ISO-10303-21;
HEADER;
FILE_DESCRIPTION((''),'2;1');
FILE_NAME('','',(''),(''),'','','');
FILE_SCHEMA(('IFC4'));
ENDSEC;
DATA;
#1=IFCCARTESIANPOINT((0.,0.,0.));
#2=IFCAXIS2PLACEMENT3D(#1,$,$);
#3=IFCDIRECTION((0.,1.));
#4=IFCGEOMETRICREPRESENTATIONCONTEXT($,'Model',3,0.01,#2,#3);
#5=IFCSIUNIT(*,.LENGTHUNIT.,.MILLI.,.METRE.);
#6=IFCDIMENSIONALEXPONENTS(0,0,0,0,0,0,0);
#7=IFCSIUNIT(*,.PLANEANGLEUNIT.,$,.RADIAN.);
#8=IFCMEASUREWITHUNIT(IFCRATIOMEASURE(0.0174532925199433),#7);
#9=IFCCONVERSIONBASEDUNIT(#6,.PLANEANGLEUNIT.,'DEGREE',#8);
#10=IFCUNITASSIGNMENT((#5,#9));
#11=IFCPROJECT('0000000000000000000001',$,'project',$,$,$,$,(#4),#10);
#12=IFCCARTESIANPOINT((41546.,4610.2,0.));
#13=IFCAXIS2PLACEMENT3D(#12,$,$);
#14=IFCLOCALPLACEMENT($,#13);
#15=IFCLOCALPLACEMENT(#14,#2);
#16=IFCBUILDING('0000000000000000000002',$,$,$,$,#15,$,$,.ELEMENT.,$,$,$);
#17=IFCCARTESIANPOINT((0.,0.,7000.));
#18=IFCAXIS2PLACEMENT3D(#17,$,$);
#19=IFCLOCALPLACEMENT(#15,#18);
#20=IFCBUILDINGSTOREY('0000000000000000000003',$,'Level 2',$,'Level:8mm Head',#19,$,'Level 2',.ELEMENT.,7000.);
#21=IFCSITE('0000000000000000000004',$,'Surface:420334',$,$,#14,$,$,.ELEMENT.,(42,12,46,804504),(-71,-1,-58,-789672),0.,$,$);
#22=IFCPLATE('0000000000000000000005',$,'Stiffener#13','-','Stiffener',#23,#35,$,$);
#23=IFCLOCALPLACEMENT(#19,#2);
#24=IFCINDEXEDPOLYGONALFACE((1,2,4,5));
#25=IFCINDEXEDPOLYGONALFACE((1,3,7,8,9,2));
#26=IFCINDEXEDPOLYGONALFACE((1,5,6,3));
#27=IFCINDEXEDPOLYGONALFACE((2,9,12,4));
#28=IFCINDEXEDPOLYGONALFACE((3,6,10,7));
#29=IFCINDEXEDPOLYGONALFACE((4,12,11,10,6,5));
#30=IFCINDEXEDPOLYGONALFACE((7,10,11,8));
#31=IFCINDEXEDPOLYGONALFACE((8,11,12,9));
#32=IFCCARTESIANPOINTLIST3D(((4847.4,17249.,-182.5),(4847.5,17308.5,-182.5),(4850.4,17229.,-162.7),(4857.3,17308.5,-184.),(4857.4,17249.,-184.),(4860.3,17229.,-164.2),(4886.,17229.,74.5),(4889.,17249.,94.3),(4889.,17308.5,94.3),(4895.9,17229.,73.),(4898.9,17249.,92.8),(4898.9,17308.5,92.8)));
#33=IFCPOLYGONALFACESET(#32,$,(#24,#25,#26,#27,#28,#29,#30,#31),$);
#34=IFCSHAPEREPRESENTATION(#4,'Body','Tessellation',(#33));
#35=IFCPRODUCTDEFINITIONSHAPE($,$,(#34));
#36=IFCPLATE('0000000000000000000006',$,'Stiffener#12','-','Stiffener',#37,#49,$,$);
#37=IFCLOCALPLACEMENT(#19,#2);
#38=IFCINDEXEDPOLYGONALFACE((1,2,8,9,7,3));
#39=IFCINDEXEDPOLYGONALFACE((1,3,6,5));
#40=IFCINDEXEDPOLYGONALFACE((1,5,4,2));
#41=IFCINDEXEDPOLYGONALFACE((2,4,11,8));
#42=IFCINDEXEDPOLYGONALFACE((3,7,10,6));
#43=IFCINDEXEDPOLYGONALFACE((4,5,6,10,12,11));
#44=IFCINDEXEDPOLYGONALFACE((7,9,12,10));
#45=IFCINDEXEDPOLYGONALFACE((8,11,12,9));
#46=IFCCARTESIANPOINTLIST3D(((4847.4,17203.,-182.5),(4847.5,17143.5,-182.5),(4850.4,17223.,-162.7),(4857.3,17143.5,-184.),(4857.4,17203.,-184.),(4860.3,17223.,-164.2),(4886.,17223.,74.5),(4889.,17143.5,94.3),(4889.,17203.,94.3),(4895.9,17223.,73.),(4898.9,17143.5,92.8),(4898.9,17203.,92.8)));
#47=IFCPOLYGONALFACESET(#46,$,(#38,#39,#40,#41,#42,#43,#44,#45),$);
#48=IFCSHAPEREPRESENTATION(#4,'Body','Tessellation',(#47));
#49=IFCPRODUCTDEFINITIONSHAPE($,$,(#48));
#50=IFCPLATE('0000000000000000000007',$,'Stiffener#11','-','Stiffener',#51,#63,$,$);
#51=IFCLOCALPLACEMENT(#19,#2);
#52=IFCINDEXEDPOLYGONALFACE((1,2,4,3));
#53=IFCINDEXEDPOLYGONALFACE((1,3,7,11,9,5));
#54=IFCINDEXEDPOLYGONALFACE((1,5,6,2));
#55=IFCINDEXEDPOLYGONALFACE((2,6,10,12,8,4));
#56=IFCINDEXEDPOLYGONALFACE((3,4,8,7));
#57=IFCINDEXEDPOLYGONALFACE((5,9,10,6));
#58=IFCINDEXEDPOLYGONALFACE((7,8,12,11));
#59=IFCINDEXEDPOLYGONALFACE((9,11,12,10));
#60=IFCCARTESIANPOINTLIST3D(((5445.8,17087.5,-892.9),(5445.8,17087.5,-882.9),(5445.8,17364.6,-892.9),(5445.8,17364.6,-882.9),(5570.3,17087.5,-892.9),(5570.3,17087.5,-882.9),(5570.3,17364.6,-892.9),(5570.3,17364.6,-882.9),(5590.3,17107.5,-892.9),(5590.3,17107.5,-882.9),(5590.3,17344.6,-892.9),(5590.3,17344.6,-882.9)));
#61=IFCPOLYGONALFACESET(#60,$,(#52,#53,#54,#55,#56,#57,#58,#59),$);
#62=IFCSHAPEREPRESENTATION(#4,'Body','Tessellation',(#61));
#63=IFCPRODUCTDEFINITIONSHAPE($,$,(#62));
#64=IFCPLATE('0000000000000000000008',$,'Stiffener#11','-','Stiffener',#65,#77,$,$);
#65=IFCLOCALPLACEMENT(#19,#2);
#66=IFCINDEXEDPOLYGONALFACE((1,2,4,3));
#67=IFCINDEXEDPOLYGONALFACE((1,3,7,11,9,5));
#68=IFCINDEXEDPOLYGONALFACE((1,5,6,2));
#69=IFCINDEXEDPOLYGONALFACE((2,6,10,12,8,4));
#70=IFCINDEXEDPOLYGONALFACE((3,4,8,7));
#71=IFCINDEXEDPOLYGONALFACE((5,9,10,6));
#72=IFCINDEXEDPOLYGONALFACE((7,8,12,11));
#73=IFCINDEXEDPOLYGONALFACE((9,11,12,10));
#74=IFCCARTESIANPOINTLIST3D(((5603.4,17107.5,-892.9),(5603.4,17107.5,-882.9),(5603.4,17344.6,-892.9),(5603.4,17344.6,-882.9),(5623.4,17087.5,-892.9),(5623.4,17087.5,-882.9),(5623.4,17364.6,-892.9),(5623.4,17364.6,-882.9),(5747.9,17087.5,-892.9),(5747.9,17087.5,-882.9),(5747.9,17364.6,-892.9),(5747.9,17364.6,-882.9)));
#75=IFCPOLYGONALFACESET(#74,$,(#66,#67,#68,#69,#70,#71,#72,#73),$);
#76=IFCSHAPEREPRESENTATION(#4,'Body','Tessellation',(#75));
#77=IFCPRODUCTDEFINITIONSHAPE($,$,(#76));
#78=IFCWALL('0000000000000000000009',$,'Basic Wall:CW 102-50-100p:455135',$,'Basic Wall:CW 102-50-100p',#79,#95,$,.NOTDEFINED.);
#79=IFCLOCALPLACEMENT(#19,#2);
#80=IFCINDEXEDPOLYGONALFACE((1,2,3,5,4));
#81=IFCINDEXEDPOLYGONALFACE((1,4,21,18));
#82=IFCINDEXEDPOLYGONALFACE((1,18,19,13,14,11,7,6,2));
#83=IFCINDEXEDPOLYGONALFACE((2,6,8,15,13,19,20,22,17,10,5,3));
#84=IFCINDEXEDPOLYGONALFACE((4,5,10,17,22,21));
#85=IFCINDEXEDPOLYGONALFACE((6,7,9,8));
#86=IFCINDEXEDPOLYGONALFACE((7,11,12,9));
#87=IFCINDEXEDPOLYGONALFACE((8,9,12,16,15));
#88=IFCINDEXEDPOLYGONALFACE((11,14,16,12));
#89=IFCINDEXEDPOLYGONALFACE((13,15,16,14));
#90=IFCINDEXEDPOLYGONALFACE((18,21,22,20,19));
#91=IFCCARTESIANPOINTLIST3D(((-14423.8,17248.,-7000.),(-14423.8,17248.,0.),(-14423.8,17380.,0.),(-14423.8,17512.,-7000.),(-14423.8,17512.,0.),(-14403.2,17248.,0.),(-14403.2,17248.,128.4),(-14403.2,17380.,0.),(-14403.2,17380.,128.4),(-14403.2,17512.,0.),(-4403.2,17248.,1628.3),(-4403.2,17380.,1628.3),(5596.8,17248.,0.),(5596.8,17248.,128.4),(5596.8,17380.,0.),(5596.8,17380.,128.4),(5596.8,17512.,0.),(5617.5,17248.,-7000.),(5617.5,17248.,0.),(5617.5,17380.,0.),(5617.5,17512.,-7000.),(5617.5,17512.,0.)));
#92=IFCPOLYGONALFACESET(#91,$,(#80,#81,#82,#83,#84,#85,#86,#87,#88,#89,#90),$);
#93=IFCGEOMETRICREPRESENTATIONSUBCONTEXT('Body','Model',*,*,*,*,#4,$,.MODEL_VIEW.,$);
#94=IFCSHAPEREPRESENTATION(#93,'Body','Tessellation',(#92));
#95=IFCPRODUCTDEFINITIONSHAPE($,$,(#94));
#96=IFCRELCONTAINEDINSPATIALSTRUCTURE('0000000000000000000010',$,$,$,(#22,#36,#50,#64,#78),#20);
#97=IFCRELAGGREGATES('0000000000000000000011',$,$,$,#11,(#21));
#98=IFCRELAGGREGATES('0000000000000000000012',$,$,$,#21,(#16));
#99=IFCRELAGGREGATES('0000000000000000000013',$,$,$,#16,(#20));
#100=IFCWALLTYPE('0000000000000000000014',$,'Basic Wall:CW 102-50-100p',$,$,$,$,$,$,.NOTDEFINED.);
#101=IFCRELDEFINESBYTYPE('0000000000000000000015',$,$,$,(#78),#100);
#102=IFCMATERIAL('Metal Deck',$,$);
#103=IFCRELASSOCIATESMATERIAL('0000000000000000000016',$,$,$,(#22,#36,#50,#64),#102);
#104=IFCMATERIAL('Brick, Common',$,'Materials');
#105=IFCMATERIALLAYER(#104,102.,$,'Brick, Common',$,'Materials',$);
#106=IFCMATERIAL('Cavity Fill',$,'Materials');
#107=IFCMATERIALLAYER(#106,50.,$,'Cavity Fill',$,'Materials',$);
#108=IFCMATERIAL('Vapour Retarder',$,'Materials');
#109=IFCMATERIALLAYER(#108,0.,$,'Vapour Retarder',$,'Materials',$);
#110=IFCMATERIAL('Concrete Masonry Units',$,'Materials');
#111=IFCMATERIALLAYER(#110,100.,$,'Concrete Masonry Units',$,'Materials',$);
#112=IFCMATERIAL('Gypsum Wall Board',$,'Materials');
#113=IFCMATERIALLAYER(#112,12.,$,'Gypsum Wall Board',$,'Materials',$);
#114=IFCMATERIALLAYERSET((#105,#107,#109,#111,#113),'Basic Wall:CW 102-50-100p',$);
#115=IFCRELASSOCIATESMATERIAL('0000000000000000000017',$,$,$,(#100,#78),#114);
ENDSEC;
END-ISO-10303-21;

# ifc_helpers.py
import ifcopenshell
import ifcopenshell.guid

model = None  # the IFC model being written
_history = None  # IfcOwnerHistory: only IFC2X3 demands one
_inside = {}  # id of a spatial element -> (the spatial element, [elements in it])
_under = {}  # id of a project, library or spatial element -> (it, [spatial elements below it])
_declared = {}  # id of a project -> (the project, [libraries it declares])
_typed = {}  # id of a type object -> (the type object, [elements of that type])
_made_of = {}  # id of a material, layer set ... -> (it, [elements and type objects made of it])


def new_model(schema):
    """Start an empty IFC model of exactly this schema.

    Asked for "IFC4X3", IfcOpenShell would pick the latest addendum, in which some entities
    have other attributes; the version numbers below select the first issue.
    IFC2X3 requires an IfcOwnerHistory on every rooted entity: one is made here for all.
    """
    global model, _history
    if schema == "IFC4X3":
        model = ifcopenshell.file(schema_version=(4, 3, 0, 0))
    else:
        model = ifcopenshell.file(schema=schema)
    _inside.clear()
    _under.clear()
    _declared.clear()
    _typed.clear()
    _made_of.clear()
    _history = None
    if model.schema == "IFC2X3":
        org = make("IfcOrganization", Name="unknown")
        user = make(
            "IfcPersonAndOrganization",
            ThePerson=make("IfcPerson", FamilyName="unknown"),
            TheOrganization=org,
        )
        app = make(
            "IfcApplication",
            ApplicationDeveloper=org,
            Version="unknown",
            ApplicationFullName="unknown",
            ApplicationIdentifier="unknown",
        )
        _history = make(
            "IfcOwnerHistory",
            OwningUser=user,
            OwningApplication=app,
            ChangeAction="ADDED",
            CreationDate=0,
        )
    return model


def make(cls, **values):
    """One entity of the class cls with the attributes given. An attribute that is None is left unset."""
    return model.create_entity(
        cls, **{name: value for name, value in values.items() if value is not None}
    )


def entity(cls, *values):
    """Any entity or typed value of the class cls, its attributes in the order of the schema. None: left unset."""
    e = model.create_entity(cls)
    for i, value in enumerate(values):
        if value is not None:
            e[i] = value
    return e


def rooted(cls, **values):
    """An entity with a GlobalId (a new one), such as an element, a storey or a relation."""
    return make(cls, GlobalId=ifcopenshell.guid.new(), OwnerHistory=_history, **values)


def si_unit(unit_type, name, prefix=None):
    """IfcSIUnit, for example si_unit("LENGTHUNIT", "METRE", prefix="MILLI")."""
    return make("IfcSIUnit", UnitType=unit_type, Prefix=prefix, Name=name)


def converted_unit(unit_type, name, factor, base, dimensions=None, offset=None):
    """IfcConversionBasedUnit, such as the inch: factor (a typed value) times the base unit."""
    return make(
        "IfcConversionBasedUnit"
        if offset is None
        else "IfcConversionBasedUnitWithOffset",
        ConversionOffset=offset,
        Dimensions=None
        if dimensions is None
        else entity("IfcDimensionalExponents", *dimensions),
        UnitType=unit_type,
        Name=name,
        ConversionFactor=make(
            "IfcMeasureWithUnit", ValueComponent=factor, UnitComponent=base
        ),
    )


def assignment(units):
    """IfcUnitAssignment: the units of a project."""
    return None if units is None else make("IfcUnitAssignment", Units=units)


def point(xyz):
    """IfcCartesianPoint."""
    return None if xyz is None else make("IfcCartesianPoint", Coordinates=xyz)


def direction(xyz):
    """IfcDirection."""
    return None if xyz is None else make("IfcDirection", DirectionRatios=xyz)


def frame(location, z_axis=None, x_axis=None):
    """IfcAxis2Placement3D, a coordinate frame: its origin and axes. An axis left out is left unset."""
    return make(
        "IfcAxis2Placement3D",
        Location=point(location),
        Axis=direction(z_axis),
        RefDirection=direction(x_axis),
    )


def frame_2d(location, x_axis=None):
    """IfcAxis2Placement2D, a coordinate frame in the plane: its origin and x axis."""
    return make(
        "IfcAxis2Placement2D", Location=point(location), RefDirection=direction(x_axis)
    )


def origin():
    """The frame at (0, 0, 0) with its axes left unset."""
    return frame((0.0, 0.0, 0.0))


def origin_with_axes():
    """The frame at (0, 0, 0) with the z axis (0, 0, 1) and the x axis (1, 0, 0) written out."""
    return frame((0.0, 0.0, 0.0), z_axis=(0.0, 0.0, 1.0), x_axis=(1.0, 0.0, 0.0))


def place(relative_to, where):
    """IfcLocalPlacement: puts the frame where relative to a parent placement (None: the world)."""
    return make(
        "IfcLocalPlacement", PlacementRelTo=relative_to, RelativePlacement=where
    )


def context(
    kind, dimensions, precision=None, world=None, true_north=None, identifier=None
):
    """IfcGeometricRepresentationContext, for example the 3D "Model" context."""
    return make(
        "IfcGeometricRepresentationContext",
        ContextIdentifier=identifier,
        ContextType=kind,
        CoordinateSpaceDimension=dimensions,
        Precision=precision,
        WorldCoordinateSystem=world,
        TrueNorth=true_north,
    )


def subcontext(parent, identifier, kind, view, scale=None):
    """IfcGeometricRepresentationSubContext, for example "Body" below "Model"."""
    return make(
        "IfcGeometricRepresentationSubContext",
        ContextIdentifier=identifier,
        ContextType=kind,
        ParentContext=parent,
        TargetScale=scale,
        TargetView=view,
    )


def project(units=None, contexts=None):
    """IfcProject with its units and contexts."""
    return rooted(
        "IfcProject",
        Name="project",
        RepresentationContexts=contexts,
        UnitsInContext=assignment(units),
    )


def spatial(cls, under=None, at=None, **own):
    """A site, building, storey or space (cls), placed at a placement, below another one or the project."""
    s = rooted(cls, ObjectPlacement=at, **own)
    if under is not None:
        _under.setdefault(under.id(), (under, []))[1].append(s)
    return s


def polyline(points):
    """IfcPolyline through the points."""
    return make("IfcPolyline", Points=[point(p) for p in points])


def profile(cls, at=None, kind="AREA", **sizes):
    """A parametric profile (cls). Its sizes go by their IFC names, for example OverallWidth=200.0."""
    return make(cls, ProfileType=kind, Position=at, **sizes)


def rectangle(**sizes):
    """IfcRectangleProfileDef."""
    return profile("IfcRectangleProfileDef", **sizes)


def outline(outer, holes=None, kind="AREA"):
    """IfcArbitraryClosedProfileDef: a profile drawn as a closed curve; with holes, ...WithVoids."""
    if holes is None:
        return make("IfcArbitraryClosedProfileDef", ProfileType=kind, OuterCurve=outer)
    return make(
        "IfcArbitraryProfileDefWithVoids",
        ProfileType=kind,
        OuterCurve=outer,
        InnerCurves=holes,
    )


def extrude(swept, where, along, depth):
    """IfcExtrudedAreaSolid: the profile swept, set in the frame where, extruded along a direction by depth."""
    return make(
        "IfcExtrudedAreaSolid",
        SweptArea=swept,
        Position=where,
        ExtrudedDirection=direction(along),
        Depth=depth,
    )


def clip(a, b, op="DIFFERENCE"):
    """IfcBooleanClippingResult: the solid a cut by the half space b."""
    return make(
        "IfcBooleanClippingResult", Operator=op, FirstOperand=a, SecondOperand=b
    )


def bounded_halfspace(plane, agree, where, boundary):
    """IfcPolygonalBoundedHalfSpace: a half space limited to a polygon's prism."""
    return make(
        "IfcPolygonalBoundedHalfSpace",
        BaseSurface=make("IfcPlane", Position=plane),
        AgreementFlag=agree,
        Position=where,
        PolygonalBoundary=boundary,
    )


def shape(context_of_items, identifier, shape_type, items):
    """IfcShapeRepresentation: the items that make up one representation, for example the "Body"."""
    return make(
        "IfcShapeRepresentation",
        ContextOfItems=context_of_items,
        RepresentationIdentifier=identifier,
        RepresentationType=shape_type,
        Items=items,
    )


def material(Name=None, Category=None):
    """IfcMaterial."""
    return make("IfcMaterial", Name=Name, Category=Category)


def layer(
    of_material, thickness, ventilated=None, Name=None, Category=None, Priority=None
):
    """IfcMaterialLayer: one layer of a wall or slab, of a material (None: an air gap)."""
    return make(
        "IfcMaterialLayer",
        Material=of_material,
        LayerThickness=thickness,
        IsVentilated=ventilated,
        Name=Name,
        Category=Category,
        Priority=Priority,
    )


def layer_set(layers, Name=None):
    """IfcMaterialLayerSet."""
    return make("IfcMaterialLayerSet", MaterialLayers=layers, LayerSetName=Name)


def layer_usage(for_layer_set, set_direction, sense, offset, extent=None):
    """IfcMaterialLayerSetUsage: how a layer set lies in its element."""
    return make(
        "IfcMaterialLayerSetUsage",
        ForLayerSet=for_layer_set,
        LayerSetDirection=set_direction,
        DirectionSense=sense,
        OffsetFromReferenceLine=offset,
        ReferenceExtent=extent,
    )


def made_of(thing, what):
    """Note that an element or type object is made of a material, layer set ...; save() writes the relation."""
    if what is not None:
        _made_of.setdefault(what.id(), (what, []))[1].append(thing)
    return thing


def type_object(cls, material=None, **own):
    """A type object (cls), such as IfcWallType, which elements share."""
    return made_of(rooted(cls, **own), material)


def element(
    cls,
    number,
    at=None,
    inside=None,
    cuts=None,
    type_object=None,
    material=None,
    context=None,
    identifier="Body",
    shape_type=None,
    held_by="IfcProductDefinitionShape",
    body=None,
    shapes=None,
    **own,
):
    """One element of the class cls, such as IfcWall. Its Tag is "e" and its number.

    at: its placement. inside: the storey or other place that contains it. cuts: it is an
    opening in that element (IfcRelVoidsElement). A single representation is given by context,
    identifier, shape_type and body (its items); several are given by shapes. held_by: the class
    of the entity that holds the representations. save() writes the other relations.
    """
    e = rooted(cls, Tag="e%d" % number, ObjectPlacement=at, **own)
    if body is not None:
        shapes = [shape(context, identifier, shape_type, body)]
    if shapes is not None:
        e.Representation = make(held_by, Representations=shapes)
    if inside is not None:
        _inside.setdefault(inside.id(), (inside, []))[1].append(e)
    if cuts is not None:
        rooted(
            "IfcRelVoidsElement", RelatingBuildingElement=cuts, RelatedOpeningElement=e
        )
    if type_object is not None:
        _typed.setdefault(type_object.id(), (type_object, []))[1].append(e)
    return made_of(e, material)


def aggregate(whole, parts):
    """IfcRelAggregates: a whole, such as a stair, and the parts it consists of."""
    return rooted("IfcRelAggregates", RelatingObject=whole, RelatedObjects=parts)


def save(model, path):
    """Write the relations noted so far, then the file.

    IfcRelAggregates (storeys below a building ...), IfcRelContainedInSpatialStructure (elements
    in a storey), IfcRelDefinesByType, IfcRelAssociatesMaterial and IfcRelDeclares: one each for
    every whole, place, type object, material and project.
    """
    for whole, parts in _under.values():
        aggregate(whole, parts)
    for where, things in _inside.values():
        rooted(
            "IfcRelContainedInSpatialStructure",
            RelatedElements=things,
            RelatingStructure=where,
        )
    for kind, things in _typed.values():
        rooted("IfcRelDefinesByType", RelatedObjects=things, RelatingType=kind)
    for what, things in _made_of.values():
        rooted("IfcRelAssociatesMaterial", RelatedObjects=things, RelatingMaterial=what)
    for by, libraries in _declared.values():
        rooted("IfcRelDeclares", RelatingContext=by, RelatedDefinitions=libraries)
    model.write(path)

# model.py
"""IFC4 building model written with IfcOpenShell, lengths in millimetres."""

from ifc_helpers import new_model, entity, si_unit, converted_unit, direction, frame, frame_2d, origin, origin_with_axes, place, context, subcontext, project, spatial, polyline, rectangle, outline, extrude, clip, bounded_halfspace, material, layer, layer_set, layer_usage, type_object, element, save


model = new_model("IFC4")

# Units and contexts
model_context = context("Model", 3, precision=0.01, world=origin(), true_north=direction((0.0, 1.0)))
body_context = subcontext(model_context, "Body", "Model", "MODEL_VIEW")
ifc_project = project(units=[si_unit("LENGTHUNIT", "METRE", prefix="MILLI"), converted_unit("PLANEANGLEUNIT", "DEGREE", entity("IfcRatioMeasure", 0.0174532925199433), si_unit("PLANEANGLEUNIT", "RADIAN"), dimensions=[0, 0, 0, 0, 0, 0, 0])], contexts=[model_context])

# Site, building, storey
site_placement = place(None, frame((41546.0, 4610.2, 0.0)))
site = spatial("IfcSite", under=ifc_project, at=site_placement, Name="Surface:420334", CompositionType="ELEMENT", RefLatitude=(42, 12, 46, 804504), RefLongitude=(-71, -1, -58, -789672), RefElevation=0.0)
building_placement = place(site_placement, origin())
building = spatial("IfcBuilding", under=site, at=building_placement, CompositionType="ELEMENT")
storey_placement = place(building_placement, frame((0.0, 0.0, 7000.0)))
storey = spatial("IfcBuildingStorey", under=building, at=storey_placement, Name="Level 2", ObjectType="Level:8mm Head", LongName="Level 2", CompositionType="ELEMENT", Elevation=7000.0)

# Plates, openings
ifc_material_1 = material(Name="Metal Deck")
plate_1_placement = place(storey_placement, frame((4857.3, 17308.5, -184.0), z_axis=(-0.988936, 0.0, 0.14834), x_axis=(0.0, -1.0, 0.0)))
plate_1 = element("IfcPlate", 1, at=plate_1_placement, inside=storey, material=ifc_material_1, Name="Stiffener#13", Description="-", ObjectType="Stiffener", context=model_context, shape_type="SweptSolid", body=[
    extrude(outline(polyline([(0.0, 0.0), (79.5, 0.0), (79.5, 279.8), (0.0, 279.8), (0.0, 0.0)])), origin_with_axes(), (0.0, 0.0, 1.0), 10.0),
])
opening_1_placement = place(plate_1_placement, frame((0.0, 0.0, 0.0), z_axis=(0.0, 0.0, 1.0), x_axis=(1.0, 0.0, 0.0)))
element("IfcOpeningElement", 2, at=opening_1_placement, cuts=plate_1, ObjectType="Opening", context=model_context, shape_type="SweptSolid", body=[
    extrude(outline(polyline([(79.5, 279.8), (59.5, 279.8), (79.5, 259.8), (79.5, 279.8)])), origin(), (0.0, 0.0, 1.0), 10.0),
])
opening_2_placement = place(plate_1_placement, frame((0.0, 0.0, 0.0), z_axis=(0.0, 0.0, 1.0), x_axis=(1.0, 0.0, 0.0)))
element("IfcOpeningElement", 3, at=opening_2_placement, cuts=plate_1, ObjectType="Opening", context=model_context, shape_type="SweptSolid", body=[
    extrude(outline(polyline([(79.5, 0.0), (79.5, 20.0), (59.5, 0.0), (79.5, 0.0)])), origin(), (0.0, 0.0, 1.0), 10.0),
])
plate_2_placement = place(storey_placement, frame((4857.3, 17223.0, -184.0), z_axis=(-0.988936, 0.0, 0.14834), x_axis=(0.0, -1.0, 0.0)))
plate_2 = element("IfcPlate", 4, at=plate_2_placement, inside=storey, material=ifc_material_1, Name="Stiffener#12", Description="-", ObjectType="Stiffener", context=model_context, shape_type="SweptSolid", body=[
    extrude(outline(polyline([(0.0, 0.0), (79.5, 0.0), (79.5, 279.8), (0.0, 279.8), (0.0, 0.0)])), origin_with_axes(), (0.0, 0.0, 1.0), 10.0),
])
opening_3_placement = place(plate_2_placement, frame((0.0, 0.0, 0.0), z_axis=(0.0, 0.0, 1.0), x_axis=(1.0, 0.0, 0.0)))
element("IfcOpeningElement", 5, at=opening_3_placement, cuts=plate_2, ObjectType="Opening", context=model_context, shape_type="SweptSolid", body=[
    extrude(outline(polyline([(0.0, 279.8), (0.0, 259.8), (20.0, 279.8), (0.0, 279.8)])), origin(), (0.0, 0.0, 1.0), 10.0),
])
opening_4_placement = place(plate_2_placement, frame((0.0, 0.0, 0.0), z_axis=(0.0, 0.0, 1.0), x_axis=(1.0, 0.0, 0.0)))
element("IfcOpeningElement", 6, at=opening_4_placement, cuts=plate_2, ObjectType="Opening", context=model_context, shape_type="SweptSolid", body=[
    extrude(outline(polyline([(0.0, 0.0), (20.0, 0.0), (0.0, 20.0), (0.0, 0.0)])), origin(), (0.0, 0.0, 1.0), 10.0),
])
plate_3_placement = place(storey_placement, frame((5445.8, 17087.5, -882.9), z_axis=(0.0, 0.0, -1.0), x_axis=(0.0, 1.0, 0.0)))
plate_3 = element("IfcPlate", 7, at=plate_3_placement, inside=storey, material=ifc_material_1, Name="Stiffener#11", Description="-", ObjectType="Stiffener", context=model_context, shape_type="SweptSolid", body=[
    extrude(outline(polyline([(0.0, 0.0), (277.1, 0.0), (277.1, 144.5), (0.0, 144.5), (0.0, 0.0)])), origin_with_axes(), (0.0, 0.0, 1.0), 10.0),
])
opening_5_placement = place(plate_3_placement, frame((0.0, 0.0, 0.0), z_axis=(0.0, 0.0, 1.0), x_axis=(1.0, 0.0, 0.0)))
element("IfcOpeningElement", 8, at=opening_5_placement, cuts=plate_3, ObjectType="Opening", context=model_context, shape_type="SweptSolid", body=[
    extrude(outline(polyline([(277.1, 144.5), (257.1, 144.5), (277.1, 124.5), (277.1, 144.5)])), origin(), (0.0, 0.0, 1.0), 10.0),
])
opening_6_placement = place(plate_3_placement, frame((0.0, 0.0, 0.0), z_axis=(0.0, 0.0, 1.0), x_axis=(1.0, 0.0, 0.0)))
element("IfcOpeningElement", 9, at=opening_6_placement, cuts=plate_3, ObjectType="Opening", context=model_context, shape_type="SweptSolid", body=[
    extrude(outline(polyline([(0.0, 144.5), (0.0, 124.5), (20.0, 144.5), (0.0, 144.5)])), origin(), (0.0, 0.0, 1.0), 10.0),
])
plate_4_placement = place(storey_placement, frame((5603.4, 17087.5, -882.9), z_axis=(0.0, 0.0, -1.0), x_axis=(0.0, 1.0, 0.0)))
plate_4 = element("IfcPlate", 10, at=plate_4_placement, inside=storey, material=ifc_material_1, Name="Stiffener#11", Description="-", ObjectType="Stiffener", context=model_context, shape_type="SweptSolid", body=[
    extrude(outline(polyline([(0.0, 0.0), (277.1, 0.0), (277.1, 144.5), (0.0, 144.5), (0.0, 0.0)])), origin_with_axes(), (0.0, 0.0, 1.0), 10.0),
])
opening_7_placement = place(plate_4_placement, frame((0.0, 0.0, 0.0), z_axis=(0.0, 0.0, 1.0), x_axis=(1.0, 0.0, 0.0)))
element("IfcOpeningElement", 11, at=opening_7_placement, cuts=plate_4, ObjectType="Opening", context=model_context, shape_type="SweptSolid", body=[
    extrude(outline(polyline([(277.1, 0.0), (277.1, 20.0), (257.1, 0.0), (277.1, 0.0)])), origin(), (0.0, 0.0, 1.0), 10.0),
])
opening_8_placement = place(plate_4_placement, frame((0.0, 0.0, 0.0), z_axis=(0.0, 0.0, 1.0), x_axis=(1.0, 0.0, 0.0)))
element("IfcOpeningElement", 12, at=opening_8_placement, cuts=plate_4, ObjectType="Opening", context=model_context, shape_type="SweptSolid", body=[
    extrude(outline(polyline([(0.0, 0.0), (20.0, 0.0), (0.0, 20.0), (0.0, 0.0)])), origin(), (0.0, 0.0, 1.0), 10.0),
])

# Wall
ifc_material_2 = material(Name="Brick, Common", Category="Materials")
ifc_layer_1 = layer(ifc_material_2, 102.0, Name="Brick, Common", Category="Materials")
ifc_material_3 = material(Name="Cavity Fill", Category="Materials")
ifc_layer_2 = layer(ifc_material_3, 50.0, Name="Cavity Fill", Category="Materials")
ifc_material_4 = material(Name="Vapour Retarder", Category="Materials")
ifc_layer_3 = layer(ifc_material_4, 0.0, Name="Vapour Retarder", Category="Materials")
ifc_material_5 = material(Name="Concrete Masonry Units", Category="Materials")
ifc_layer_4 = layer(ifc_material_5, 100.0, Name="Concrete Masonry Units", Category="Materials")
ifc_material_6 = material(Name="Gypsum Wall Board", Category="Materials")
ifc_layer_5 = layer(ifc_material_6, 12.0, Name="Gypsum Wall Board", Category="Materials")
ifc_layer_set = layer_set([ifc_layer_1, ifc_layer_2, ifc_layer_3, ifc_layer_4, ifc_layer_5], Name="Basic Wall:CW 102-50-100p")
ifc_layer_usage = layer_usage(ifc_layer_set, "AXIS2", "NEGATIVE", 132.0)
wall_type = type_object("IfcWallType", Name="Basic Wall:CW 102-50-100p", PredefinedType="NOTDEFINED", material=ifc_layer_set)
wall_placement = place(storey_placement, frame((5617.5, 17380.0, -7000.0), z_axis=(0.0, 0.0, 1.0), x_axis=(-1.0, 0.0, 0.0)))
element("IfcWall", 13, at=wall_placement, inside=storey, type_object=wall_type, material=ifc_layer_usage, Name="Basic Wall:CW 102-50-100p:455135", ObjectType="Basic Wall:CW 102-50-100p", PredefinedType="NOTDEFINED", context=body_context, shape_type="Clipping", body=[
    clip(clip(clip(clip(clip(clip(clip(extrude(rectangle(XDim=20041.3, YDim=264.0, at=frame_2d((10020.6, 0.0), x_axis=(-1.0, 0.0))), origin(), (0.0, 0.0, 1.0), 8628.3), bounded_halfspace(frame((20020.6, 0.0, 7128.4), z_axis=(0.148327, 0.0, 0.988938), x_axis=(0.0, 1.0, 0.0)), False, frame((20020.6, 0.0, 7128.4)), polyline([(0.0, 0.0), (0.0, 132.0), (-10000.0, 132.0), (-10000.0, 0.0), (0.0, 0.0)]))), bounded_halfspace(frame((10020.6, 132.0, 8628.3), z_axis=(-0.148327, 0.0, 0.988938), x_axis=(0.0, -1.0, 0.0)), False, frame((10020.6, 132.0, 8628.3)), polyline([(0.0, 0.0), (-10000.0, 0.0), (-10000.0, -132.0), (0.0, -132.0), (0.0, 0.0)]))), bounded_halfspace(frame((20041.3, 0.0, 7000.0), z_axis=(0.0, 0.0, 1.0), x_axis=(0.0, 1.0, 0.0)), False, frame((20041.3, 0.0, 7000.0)), polyline([(0.0, 0.0), (0.0, 132.0), (-20.6, 132.0), (-20.6, 0.0), (0.0, 0.0)]))), bounded_halfspace(frame((20020.6, -132.0, 7000.0), z_axis=(0.0, 0.0, 1.0), x_axis=(0.0, 1.0, 0.0)), False, frame((20020.6, -132.0, 7000.0)), polyline([(0.0, 0.0), (20.6, 0.0), (20.6, 132.0), (0.0, 132.0), (0.0, 0.0)]))), bounded_halfspace(frame((20.6, 132.0, 7000.0), z_axis=(0.0, 0.0, 1.0), x_axis=(0.0, 1.0, 0.0)), False, frame((20.6, 132.0, 7000.0)), polyline([(0.0, 0.0), (-20.6, 0.0), (-20.6, -132.0), (0.0, -132.0), (0.0, 0.0)]))), bounded_halfspace(frame((20.6, -132.0, 7000.0), z_axis=(0.0, 0.0, 1.0), x_axis=(0.0, 1.0, 0.0)), False, frame((20.6, -132.0, 7000.0)), polyline([(0.0, 0.0), (20000.0, 0.0), (20000.0, 132.0), (0.0, 132.0), (0.0, 0.0)]))), bounded_halfspace(frame((0.0, -132.0, 7000.0), z_axis=(0.0, 0.0, 1.0), x_axis=(0.0, 1.0, 0.0)), False, frame((0.0, -132.0, 7000.0)), polyline([(0.0, 0.0), (20.6, 0.0), (20.6, 132.0), (0.0, 132.0), (0.0, 0.0)]))),
])

save(model, "model.ifc")
